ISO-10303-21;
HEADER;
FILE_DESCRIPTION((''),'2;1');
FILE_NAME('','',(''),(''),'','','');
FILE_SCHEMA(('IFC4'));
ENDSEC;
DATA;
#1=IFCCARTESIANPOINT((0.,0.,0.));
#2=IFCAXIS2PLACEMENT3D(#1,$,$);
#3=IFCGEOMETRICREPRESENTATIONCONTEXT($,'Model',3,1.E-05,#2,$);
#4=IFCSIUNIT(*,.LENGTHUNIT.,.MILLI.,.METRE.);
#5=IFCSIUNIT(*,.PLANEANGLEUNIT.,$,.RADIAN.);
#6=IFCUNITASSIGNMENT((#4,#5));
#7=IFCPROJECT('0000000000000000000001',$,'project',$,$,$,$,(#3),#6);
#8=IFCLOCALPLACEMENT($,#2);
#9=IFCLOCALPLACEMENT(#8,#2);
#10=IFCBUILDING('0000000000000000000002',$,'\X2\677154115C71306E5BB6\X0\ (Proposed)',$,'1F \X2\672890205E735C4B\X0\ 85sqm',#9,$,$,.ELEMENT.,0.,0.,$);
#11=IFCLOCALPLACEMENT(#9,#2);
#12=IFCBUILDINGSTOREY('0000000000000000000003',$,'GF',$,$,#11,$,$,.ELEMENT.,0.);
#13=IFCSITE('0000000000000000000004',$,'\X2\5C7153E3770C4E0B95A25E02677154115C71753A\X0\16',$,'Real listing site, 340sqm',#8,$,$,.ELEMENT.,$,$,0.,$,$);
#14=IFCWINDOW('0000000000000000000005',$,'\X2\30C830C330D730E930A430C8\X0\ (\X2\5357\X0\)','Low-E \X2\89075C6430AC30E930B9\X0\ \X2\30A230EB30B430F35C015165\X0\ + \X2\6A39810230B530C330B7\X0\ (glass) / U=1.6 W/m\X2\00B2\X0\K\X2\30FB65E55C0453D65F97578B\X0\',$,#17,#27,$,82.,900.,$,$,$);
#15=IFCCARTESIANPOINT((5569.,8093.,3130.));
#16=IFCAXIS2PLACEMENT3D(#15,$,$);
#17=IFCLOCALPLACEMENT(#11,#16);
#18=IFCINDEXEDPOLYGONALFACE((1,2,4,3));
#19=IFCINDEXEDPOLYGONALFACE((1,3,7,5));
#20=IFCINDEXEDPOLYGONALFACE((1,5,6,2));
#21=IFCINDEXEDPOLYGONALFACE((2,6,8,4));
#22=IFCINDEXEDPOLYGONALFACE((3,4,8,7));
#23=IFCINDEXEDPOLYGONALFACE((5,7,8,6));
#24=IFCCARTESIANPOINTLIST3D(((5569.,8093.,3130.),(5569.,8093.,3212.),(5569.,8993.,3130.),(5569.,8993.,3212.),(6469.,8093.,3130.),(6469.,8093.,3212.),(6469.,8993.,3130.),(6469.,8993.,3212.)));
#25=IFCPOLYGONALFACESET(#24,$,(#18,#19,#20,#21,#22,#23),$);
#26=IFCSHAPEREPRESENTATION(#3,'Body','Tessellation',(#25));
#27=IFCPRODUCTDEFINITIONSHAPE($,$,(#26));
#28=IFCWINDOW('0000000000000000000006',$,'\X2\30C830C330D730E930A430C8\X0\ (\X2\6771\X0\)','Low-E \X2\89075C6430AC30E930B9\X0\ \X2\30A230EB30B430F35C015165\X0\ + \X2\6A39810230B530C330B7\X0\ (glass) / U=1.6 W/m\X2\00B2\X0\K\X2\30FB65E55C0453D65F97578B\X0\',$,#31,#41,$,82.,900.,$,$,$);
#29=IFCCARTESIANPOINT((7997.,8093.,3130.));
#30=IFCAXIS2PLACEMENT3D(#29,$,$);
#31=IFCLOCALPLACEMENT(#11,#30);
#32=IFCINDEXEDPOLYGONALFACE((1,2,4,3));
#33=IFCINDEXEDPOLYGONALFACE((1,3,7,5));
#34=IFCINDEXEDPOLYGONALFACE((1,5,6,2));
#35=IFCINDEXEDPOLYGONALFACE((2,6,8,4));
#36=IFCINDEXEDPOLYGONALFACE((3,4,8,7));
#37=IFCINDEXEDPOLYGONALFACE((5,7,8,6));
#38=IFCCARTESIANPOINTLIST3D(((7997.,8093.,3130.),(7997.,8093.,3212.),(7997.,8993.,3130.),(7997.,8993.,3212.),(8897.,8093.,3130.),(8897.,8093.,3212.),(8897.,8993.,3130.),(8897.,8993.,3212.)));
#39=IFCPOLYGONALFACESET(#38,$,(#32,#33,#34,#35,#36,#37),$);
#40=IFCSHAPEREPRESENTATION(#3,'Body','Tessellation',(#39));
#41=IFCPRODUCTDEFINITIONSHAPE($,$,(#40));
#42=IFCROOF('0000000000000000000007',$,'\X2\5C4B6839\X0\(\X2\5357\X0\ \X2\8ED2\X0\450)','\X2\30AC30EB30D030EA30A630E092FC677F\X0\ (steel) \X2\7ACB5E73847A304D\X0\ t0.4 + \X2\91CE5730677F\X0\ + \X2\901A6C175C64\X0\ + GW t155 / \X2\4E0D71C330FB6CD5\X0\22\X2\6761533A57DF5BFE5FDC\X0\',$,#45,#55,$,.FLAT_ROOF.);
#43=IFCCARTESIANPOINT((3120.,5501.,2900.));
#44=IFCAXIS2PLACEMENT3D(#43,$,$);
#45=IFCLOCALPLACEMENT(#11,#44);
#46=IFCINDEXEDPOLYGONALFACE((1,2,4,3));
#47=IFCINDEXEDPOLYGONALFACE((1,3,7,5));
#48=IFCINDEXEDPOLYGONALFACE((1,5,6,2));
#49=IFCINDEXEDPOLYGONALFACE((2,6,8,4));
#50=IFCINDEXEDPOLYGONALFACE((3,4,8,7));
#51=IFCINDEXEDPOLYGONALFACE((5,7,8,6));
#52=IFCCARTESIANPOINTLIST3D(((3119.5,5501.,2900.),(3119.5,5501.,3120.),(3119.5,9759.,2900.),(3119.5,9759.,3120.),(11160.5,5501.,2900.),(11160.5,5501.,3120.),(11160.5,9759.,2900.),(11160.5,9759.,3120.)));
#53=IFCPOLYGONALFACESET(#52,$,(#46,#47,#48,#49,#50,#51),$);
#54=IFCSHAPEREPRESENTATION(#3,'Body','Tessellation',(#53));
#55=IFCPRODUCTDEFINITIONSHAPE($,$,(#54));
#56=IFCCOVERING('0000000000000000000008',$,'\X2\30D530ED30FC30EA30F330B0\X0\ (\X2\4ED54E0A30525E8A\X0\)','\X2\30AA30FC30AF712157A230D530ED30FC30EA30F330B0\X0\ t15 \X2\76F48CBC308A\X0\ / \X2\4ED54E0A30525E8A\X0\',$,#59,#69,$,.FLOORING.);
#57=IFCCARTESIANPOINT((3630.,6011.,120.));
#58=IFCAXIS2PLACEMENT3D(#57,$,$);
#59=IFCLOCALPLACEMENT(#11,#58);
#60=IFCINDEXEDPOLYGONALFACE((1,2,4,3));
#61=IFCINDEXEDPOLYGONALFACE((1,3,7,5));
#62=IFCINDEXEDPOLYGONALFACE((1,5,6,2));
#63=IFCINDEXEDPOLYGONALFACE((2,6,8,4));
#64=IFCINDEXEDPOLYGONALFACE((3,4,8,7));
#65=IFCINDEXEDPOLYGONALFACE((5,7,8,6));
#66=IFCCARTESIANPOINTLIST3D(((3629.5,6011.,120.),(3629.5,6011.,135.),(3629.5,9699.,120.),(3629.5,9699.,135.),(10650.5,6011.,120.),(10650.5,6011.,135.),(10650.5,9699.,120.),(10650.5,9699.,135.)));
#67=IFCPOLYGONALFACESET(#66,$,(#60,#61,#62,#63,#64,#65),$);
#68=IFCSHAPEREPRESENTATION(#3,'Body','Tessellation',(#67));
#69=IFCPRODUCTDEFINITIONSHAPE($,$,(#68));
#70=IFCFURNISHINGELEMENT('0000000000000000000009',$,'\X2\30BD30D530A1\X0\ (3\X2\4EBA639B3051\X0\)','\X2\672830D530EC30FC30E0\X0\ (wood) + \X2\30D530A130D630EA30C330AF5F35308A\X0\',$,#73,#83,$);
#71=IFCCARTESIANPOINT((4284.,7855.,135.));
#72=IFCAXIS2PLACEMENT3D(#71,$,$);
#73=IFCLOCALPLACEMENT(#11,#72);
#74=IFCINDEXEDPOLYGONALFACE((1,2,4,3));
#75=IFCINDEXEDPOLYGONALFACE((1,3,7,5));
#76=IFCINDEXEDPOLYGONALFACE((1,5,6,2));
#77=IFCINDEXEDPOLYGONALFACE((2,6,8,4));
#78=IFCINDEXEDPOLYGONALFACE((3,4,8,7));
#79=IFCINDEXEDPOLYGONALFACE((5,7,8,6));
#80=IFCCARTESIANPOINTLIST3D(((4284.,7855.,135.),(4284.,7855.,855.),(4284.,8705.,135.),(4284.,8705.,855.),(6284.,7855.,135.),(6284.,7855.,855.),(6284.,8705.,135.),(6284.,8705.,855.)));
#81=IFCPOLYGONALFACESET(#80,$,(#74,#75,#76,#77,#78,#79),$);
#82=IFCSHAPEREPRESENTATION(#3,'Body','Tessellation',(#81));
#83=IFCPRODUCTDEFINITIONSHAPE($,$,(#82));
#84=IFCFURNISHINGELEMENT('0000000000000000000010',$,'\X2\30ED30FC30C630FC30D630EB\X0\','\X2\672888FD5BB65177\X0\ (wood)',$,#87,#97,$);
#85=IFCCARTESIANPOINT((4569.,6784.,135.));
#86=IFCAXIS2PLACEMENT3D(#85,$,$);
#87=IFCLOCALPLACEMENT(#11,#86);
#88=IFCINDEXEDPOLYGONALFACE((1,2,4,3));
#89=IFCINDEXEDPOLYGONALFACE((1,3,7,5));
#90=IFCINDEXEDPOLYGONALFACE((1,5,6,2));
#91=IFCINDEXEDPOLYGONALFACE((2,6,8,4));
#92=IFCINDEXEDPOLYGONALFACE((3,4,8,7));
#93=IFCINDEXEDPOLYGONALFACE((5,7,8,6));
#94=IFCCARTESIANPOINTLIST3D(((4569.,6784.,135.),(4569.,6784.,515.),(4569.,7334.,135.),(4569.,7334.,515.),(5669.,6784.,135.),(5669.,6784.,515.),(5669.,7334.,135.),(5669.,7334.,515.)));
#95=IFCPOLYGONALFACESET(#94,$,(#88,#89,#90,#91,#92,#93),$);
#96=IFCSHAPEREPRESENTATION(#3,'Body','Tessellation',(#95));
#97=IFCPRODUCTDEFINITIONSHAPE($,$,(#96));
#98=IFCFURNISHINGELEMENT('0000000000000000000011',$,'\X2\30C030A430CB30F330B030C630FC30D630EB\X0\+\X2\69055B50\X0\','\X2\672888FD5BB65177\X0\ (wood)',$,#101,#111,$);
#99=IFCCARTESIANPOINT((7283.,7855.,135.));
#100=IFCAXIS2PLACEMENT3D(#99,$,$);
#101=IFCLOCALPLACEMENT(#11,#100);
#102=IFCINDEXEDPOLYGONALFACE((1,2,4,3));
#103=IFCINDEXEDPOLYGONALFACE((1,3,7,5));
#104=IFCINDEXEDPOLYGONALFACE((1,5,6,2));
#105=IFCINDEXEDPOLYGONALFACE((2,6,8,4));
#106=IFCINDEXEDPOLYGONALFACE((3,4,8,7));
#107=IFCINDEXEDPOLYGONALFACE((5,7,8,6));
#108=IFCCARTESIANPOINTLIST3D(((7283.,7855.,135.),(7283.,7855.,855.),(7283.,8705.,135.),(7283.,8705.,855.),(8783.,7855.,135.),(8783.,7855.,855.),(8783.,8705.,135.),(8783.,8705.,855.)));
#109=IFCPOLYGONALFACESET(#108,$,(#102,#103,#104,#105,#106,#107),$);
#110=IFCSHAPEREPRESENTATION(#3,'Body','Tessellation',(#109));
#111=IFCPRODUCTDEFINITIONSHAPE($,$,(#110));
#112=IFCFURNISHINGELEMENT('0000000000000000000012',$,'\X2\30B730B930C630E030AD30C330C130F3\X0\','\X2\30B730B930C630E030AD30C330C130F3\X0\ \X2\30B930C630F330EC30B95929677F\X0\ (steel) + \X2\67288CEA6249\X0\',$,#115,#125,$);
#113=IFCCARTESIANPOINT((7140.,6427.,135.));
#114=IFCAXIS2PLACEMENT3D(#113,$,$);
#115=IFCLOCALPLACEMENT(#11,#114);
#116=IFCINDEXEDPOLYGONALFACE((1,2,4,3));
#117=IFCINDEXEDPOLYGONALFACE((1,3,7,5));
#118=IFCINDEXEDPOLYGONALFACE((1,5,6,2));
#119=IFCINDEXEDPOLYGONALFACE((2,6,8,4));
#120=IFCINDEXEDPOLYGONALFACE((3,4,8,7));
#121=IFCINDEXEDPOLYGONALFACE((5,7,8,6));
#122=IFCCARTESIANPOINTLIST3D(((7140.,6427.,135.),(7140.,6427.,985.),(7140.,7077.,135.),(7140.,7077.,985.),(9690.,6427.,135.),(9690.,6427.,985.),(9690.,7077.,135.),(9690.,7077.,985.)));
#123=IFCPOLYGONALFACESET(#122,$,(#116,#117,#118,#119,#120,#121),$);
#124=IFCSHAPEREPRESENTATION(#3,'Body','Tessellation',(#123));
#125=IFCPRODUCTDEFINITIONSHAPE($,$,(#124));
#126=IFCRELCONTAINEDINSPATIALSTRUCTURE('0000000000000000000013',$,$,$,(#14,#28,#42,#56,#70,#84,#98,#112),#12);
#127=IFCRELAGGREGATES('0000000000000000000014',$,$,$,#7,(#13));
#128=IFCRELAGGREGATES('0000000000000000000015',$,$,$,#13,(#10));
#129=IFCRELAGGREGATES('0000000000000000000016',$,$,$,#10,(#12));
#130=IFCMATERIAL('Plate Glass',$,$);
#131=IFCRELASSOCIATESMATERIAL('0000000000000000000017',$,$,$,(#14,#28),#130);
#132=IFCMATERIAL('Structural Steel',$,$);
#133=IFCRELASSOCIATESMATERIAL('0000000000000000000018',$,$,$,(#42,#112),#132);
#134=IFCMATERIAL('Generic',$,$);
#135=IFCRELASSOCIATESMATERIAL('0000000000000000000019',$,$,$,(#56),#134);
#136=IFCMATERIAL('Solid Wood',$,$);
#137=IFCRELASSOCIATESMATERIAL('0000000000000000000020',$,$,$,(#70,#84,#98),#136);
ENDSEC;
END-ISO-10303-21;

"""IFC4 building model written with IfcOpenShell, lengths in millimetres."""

from ifc_helpers import new_model, si_unit, frame, frame_2d, origin, place, context, project, spatial, rectangle, extrude, material, element, save


model = new_model("IFC4")

# Units and contexts
model_context = context("Model", 3, precision=1e-05, world=origin())
ifc_project = project(units=[si_unit("LENGTHUNIT", "METRE", prefix="MILLI"), si_unit("PLANEANGLEUNIT", "RADIAN")], contexts=[model_context])

# Site, building, storey
site_placement = place(None, origin())
site = spatial("IfcSite", under=ifc_project, at=site_placement, Name="山口県下関市東向山町16", ObjectType="Real listing site, 340sqm", CompositionType="ELEMENT", RefElevation=0.0)
building_placement = place(site_placement, origin())
building = spatial("IfcBuilding", under=site, at=building_placement, Name="東向山の家 (Proposed)", ObjectType="1F 木造平屋 85sqm", CompositionType="ELEMENT", ElevationOfRefHeight=0.0, ElevationOfTerrain=0.0)
storey_placement = place(building_placement, origin())
storey = spatial("IfcBuildingStorey", under=building, at=storey_placement, Name="GF", CompositionType="ELEMENT", Elevation=0.0)

# Shared definitions
ifc_material_1 = material(Name="Solid Wood")

# Shared definitions
ifc_material_2 = material(Name="Plate Glass")

# Windows
window_1_placement = place(storey_placement, frame((5569.0, 8093.0, 3130.0)))
element("IfcWindow", 1, at=window_1_placement, inside=storey, material=ifc_material_2, Name="トップライト (南)", Description="Low-E 複層ガラス アルゴン封入 + 樹脂サッシ (glass) / U=1.6 W/m²K・日射取得型", OverallHeight=82.0, OverallWidth=900.0, context=model_context, shape_type="SweptSolid", body=[
    extrude(rectangle(XDim=900.0, YDim=900.0, at=frame_2d((450.0, 450.0))), frame((5569.0, 8093.0, 3130.0)), (0.0, 0.0, 1.0), 82.0),
])
window_2_placement = place(storey_placement, frame((7997.0, 8093.0, 3130.0)))
element("IfcWindow", 2, at=window_2_placement, inside=storey, material=ifc_material_2, Name="トップライト (東)", Description="Low-E 複層ガラス アルゴン封入 + 樹脂サッシ (glass) / U=1.6 W/m²K・日射取得型", OverallHeight=82.0, OverallWidth=900.0, context=model_context, shape_type="SweptSolid", body=[
    extrude(rectangle(XDim=900.0, YDim=900.0, at=frame_2d((450.0, 450.0))), frame((7997.0, 8093.0, 3130.0)), (0.0, 0.0, 1.0), 82.0),
])

# Roof
ifc_material_3 = material(Name="Structural Steel")
roof_placement = place(storey_placement, frame((3120.0, 5501.0, 2900.0)))
element("IfcRoof", 3, at=roof_placement, inside=storey, material=ifc_material_3, Name="屋根(南 軒450)", Description="ガルバリウム鋼板 (steel) 立平葺き t0.4 + 野地板 + 通気層 + GW t155 / 不燃・法22条区域対応", PredefinedType="FLAT_ROOF", context=model_context, shape_type="SweptSolid", body=[
    extrude(rectangle(XDim=8041.0, YDim=4258.0, at=frame_2d((4020.0, 2129.0))), frame((3120.0, 5501.0, 2900.0)), (0.0, 0.0, 1.0), 220.0),
])

# Covering
ifc_material_4 = material(Name="Generic")
covering_placement = place(storey_placement, frame((3630.0, 6011.0, 120.0)))
element("IfcCovering", 4, at=covering_placement, inside=storey, material=ifc_material_4, Name="フローリング (仕上げ床)", Description="オーク無垢フローリング t15 直貼り / 仕上げ床", PredefinedType="FLOORING", context=model_context, shape_type="SweptSolid", body=[
    extrude(rectangle(XDim=7021.0, YDim=3688.0, at=frame_2d((3510.0, 1844.0))), frame((3630.0, 6011.0, 120.0)), (0.0, 0.0, 1.0), 15.0),
])

# Furnishing elements
furnishing_1_placement = place(storey_placement, frame((4284.0, 7855.0, 135.0)))
element("IfcFurnishingElement", 5, at=furnishing_1_placement, inside=storey, material=ifc_material_1, Name="ソファ (3人掛け)", Description="木フレーム (wood) + ファブリック張り", context=model_context, shape_type="SweptSolid", body=[
    extrude(rectangle(XDim=2000.0, YDim=850.0, at=frame_2d((1000.0, 425.0))), frame((4284.0, 7855.0, 135.0)), (0.0, 0.0, 1.0), 720.0),
])
furnishing_2_placement = place(storey_placement, frame((4569.0, 6784.0, 135.0)))
element("IfcFurnishingElement", 6, at=furnishing_2_placement, inside=storey, material=ifc_material_1, Name="ローテーブル", Description="木製家具 (wood)", context=model_context, shape_type="SweptSolid", body=[
    extrude(rectangle(XDim=1100.0, YDim=550.0, at=frame_2d((550.0, 275.0))), frame((4569.0, 6784.0, 135.0)), (0.0, 0.0, 1.0), 380.0),
])
furnishing_3_placement = place(storey_placement, frame((7283.0, 7855.0, 135.0)))
element("IfcFurnishingElement", 7, at=furnishing_3_placement, inside=storey, material=ifc_material_1, Name="ダイニングテーブル+椅子", Description="木製家具 (wood)", context=model_context, shape_type="SweptSolid", body=[
    extrude(rectangle(XDim=1500.0, YDim=850.0, at=frame_2d((750.0, 425.0))), frame((7283.0, 7855.0, 135.0)), (0.0, 0.0, 1.0), 720.0),
])
furnishing_4_placement = place(storey_placement, frame((7140.0, 6427.0, 135.0)))
element("IfcFurnishingElement", 8, at=furnishing_4_placement, inside=storey, material=ifc_material_3, Name="システムキッチン", Description="システムキッチン ステンレス天板 (steel) + 木質扉", context=model_context, shape_type="SweptSolid", body=[
    extrude(rectangle(XDim=2550.0, YDim=650.0, at=frame_2d((1275.0, 325.0))), frame((7140.0, 6427.0, 135.0)), (0.0, 0.0, 1.0), 850.0),
])

save(model, "model.ifc")
